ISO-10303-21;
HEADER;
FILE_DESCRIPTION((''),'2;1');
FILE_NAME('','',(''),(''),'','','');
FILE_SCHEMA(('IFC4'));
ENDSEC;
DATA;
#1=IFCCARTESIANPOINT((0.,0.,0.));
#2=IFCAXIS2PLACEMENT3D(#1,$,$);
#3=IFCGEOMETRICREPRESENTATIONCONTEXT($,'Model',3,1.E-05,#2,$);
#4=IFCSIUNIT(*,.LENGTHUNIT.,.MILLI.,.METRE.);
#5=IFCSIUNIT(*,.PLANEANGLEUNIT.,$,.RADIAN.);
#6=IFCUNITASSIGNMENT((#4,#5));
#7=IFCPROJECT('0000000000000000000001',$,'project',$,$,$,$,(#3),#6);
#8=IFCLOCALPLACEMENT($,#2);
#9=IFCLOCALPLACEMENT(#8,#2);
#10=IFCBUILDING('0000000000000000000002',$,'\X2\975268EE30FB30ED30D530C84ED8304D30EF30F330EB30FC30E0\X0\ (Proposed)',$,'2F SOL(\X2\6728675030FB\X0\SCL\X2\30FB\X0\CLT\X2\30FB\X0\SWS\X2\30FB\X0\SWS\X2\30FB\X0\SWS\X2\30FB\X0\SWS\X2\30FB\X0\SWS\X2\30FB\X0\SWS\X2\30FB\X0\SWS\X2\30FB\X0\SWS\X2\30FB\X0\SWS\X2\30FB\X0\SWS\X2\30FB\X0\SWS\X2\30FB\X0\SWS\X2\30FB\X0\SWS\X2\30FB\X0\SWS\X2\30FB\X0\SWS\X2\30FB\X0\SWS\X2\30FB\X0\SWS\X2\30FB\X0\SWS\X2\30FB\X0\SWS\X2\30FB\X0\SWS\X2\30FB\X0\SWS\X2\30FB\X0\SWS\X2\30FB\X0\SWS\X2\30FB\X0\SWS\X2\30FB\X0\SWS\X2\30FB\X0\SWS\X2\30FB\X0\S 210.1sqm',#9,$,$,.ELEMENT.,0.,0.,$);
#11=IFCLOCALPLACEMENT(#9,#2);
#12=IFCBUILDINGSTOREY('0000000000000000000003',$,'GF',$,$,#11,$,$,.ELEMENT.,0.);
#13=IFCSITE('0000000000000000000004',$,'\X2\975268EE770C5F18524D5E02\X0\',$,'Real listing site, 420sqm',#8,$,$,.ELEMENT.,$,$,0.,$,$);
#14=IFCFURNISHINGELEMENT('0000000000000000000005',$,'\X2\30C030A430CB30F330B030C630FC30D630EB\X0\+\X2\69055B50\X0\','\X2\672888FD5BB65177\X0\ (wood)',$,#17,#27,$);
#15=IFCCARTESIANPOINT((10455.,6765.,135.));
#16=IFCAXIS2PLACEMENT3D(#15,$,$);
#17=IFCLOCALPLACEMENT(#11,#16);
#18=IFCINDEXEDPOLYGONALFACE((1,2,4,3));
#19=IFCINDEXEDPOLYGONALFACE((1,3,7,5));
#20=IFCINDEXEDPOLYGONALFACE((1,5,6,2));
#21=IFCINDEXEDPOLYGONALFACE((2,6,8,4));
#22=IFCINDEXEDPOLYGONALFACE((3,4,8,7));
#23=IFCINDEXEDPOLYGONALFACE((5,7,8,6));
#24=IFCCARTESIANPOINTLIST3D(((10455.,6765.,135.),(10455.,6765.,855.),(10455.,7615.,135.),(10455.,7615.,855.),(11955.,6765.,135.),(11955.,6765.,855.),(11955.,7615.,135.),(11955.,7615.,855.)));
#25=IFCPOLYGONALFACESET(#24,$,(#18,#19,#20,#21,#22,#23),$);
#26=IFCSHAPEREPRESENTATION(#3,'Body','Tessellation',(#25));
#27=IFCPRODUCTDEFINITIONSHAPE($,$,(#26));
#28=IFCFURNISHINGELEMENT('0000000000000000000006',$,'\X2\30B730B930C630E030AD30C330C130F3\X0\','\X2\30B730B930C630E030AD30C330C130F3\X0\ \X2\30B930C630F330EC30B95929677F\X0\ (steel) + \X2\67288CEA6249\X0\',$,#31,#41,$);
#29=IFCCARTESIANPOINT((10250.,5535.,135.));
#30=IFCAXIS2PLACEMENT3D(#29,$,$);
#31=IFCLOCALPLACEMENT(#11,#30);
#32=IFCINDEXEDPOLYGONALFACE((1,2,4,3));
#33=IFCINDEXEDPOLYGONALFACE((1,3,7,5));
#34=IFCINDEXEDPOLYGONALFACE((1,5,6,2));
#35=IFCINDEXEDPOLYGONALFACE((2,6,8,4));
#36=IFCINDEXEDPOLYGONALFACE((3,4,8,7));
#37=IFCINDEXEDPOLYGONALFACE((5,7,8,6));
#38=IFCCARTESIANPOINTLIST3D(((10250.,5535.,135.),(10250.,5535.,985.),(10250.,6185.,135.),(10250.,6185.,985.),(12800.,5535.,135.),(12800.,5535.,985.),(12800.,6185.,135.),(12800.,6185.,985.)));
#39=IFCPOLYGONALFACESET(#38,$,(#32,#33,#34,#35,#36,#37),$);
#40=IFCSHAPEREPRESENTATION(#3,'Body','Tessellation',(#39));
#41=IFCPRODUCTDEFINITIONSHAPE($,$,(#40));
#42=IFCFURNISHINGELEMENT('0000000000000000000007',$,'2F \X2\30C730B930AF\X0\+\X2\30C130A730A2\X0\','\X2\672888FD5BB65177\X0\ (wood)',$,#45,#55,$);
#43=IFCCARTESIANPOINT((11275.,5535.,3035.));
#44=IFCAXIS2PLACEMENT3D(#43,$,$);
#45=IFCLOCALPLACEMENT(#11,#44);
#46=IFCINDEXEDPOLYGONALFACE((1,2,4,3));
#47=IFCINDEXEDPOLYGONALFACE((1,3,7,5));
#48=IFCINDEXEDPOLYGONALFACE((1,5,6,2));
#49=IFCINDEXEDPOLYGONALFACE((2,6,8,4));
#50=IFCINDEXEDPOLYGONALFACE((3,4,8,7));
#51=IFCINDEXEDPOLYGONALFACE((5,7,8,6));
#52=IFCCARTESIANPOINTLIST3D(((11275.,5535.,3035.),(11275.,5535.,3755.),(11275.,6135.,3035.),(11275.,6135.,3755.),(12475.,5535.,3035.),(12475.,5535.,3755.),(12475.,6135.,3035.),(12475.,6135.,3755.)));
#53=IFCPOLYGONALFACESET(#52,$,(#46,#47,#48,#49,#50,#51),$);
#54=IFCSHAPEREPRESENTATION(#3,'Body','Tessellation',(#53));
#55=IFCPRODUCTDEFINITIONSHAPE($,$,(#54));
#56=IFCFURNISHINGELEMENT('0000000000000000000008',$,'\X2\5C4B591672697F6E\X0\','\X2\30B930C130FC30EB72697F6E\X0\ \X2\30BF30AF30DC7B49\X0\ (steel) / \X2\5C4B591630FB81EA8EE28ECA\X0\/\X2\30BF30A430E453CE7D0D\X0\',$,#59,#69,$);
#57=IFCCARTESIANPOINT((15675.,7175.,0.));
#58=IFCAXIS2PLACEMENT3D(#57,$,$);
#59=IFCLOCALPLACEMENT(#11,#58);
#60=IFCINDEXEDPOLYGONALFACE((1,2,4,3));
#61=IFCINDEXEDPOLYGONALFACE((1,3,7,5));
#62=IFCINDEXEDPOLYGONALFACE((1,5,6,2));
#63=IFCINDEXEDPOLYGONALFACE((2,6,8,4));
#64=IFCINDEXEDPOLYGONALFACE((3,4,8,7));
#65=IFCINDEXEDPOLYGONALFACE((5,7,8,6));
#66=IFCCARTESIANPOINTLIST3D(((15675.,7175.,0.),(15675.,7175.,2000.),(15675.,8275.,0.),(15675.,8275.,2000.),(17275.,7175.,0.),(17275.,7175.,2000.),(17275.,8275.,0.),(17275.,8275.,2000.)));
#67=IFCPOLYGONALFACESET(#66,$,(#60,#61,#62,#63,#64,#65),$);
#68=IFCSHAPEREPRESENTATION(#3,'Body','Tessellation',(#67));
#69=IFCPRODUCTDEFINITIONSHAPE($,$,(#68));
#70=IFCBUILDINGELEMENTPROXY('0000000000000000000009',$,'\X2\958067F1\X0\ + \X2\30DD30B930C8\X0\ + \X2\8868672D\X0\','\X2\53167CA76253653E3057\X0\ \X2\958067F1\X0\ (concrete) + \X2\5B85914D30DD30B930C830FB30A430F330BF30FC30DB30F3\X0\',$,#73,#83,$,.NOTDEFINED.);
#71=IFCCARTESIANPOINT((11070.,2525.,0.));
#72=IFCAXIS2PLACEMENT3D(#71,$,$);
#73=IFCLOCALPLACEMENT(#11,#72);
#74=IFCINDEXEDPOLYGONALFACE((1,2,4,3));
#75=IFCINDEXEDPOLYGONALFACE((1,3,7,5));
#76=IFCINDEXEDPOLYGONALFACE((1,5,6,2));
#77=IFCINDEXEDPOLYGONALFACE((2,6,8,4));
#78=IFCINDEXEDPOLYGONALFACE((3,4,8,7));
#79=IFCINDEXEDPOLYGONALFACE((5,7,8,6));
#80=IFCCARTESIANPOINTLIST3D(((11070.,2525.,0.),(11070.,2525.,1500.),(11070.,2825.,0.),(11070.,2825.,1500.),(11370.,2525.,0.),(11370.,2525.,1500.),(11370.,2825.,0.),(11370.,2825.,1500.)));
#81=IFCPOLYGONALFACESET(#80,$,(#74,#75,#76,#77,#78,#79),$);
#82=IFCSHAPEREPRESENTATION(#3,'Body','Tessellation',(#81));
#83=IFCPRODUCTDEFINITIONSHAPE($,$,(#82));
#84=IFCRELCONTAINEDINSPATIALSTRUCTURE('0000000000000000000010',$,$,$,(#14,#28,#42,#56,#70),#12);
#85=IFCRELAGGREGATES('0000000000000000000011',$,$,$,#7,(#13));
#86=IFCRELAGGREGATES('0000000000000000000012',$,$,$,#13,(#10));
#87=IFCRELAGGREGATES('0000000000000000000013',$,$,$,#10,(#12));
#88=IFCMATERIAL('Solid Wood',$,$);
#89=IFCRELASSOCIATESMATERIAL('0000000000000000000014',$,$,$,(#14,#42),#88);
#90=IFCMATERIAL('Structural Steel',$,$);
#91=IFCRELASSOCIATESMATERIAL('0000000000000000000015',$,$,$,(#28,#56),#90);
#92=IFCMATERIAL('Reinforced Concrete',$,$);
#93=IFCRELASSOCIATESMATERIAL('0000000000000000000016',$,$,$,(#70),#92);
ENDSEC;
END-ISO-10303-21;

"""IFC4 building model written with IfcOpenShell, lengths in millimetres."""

from ifc_helpers import new_model, si_unit, frame, frame_2d, origin, place, context, project, spatial, rectangle, extrude, material, element, save


model = new_model("IFC4")

# Units and contexts
model_context = context("Model", 3, precision=1e-05, world=origin())
ifc_project = project(units=[si_unit("LENGTHUNIT", "METRE", prefix="MILLI"), si_unit("PLANEANGLEUNIT", "RADIAN")], contexts=[model_context])

# Site, building, storey
site_placement = place(None, origin())
site = spatial("IfcSite", under=ifc_project, at=site_placement, Name="青森県弘前市", ObjectType="Real listing site, 420sqm", CompositionType="ELEMENT", RefElevation=0.0)
building_placement = place(site_placement, origin())
building = spatial("IfcBuilding", under=site, at=building_placement, Name="青森・ロフト付きワンルーム (Proposed)", ObjectType="2F SOL(木材・SCL・CLT・SWS・SWS・SWS・SWS・SWS・SWS・SWS・SWS・SWS・SWS・SWS・SWS・SWS・SWS・SWS・SWS・SWS・SWS・SWS・SWS・SWS・SWS・SWS・SWS・SWS・SWS・S 210.1sqm", CompositionType="ELEMENT", ElevationOfRefHeight=0.0, ElevationOfTerrain=0.0)
storey_placement = place(building_placement, origin())
storey = spatial("IfcBuildingStorey", under=building, at=storey_placement, Name="GF", CompositionType="ELEMENT", Elevation=0.0)

# Shared definitions
ifc_material_1 = material(Name="Solid Wood")

# Shared definitions
ifc_material_2 = material(Name="Reinforced Concrete")

# Shared definitions
ifc_material_3 = material(Name="Structural Steel")

# Furnishing elements
furnishing_1_placement = place(storey_placement, frame((10455.0, 6765.0, 135.0)))
element("IfcFurnishingElement", 1, at=furnishing_1_placement, inside=storey, material=ifc_material_1, Name="ダイニングテーブル+椅子", Description="木製家具 (wood)", context=model_context, shape_type="SweptSolid", body=[
    extrude(rectangle(XDim=1500.0, YDim=850.0, at=frame_2d((750.0, 425.0))), frame((10455.0, 6765.0, 135.0)), (0.0, 0.0, 1.0), 720.0),
])
furnishing_2_placement = place(storey_placement, frame((10250.0, 5535.0, 135.0)))
element("IfcFurnishingElement", 2, at=furnishing_2_placement, inside=storey, material=ifc_material_3, Name="システムキッチン", Description="システムキッチン ステンレス天板 (steel) + 木質扉", context=model_context, shape_type="SweptSolid", body=[
    extrude(rectangle(XDim=2550.0, YDim=650.0, at=frame_2d((1275.0, 325.0))), frame((10250.0, 5535.0, 135.0)), (0.0, 0.0, 1.0), 850.0),
])
furnishing_3_placement = place(storey_placement, frame((11275.0, 5535.0, 3035.0)))
element("IfcFurnishingElement", 3, at=furnishing_3_placement, inside=storey, material=ifc_material_1, Name="2F デスク+チェア", Description="木製家具 (wood)", context=model_context, shape_type="SweptSolid", body=[
    extrude(rectangle(XDim=1200.0, YDim=600.0, at=frame_2d((600.0, 300.0))), frame((11275.0, 5535.0, 3035.0)), (0.0, 0.0, 1.0), 720.0),
])
furnishing_4_placement = place(storey_placement, frame((15675.0, 7175.0, 0.0)))
element("IfcFurnishingElement", 4, at=furnishing_4_placement, inside=storey, material=ifc_material_3, Name="屋外物置", Description="スチール物置 タクボ等 (steel) / 屋外・自転車/タイヤ収納", context=model_context, shape_type="SweptSolid", body=[
    extrude(rectangle(XDim=1600.0, YDim=1100.0, at=frame_2d((800.0, 550.0))), frame((15675.0, 7175.0, 0.0)), (0.0, 0.0, 1.0), 2000.0),
])

# Building element proxy
proxy_placement = place(storey_placement, frame((11070.0, 2525.0, 0.0)))
element("IfcBuildingElementProxy", 5, at=proxy_placement, inside=storey, material=ifc_material_2, Name="門柱 + ポスト + 表札", Description="化粧打放し 門柱 (concrete) + 宅配ポスト・インターホン", PredefinedType="NOTDEFINED", context=model_context, shape_type="SweptSolid", body=[
    extrude(rectangle(XDim=300.0, YDim=300.0, at=frame_2d((150.0, 150.0))), frame((11070.0, 2525.0, 0.0)), (0.0, 0.0, 1.0), 1500.0),
])

save(model, "model.ifc")
